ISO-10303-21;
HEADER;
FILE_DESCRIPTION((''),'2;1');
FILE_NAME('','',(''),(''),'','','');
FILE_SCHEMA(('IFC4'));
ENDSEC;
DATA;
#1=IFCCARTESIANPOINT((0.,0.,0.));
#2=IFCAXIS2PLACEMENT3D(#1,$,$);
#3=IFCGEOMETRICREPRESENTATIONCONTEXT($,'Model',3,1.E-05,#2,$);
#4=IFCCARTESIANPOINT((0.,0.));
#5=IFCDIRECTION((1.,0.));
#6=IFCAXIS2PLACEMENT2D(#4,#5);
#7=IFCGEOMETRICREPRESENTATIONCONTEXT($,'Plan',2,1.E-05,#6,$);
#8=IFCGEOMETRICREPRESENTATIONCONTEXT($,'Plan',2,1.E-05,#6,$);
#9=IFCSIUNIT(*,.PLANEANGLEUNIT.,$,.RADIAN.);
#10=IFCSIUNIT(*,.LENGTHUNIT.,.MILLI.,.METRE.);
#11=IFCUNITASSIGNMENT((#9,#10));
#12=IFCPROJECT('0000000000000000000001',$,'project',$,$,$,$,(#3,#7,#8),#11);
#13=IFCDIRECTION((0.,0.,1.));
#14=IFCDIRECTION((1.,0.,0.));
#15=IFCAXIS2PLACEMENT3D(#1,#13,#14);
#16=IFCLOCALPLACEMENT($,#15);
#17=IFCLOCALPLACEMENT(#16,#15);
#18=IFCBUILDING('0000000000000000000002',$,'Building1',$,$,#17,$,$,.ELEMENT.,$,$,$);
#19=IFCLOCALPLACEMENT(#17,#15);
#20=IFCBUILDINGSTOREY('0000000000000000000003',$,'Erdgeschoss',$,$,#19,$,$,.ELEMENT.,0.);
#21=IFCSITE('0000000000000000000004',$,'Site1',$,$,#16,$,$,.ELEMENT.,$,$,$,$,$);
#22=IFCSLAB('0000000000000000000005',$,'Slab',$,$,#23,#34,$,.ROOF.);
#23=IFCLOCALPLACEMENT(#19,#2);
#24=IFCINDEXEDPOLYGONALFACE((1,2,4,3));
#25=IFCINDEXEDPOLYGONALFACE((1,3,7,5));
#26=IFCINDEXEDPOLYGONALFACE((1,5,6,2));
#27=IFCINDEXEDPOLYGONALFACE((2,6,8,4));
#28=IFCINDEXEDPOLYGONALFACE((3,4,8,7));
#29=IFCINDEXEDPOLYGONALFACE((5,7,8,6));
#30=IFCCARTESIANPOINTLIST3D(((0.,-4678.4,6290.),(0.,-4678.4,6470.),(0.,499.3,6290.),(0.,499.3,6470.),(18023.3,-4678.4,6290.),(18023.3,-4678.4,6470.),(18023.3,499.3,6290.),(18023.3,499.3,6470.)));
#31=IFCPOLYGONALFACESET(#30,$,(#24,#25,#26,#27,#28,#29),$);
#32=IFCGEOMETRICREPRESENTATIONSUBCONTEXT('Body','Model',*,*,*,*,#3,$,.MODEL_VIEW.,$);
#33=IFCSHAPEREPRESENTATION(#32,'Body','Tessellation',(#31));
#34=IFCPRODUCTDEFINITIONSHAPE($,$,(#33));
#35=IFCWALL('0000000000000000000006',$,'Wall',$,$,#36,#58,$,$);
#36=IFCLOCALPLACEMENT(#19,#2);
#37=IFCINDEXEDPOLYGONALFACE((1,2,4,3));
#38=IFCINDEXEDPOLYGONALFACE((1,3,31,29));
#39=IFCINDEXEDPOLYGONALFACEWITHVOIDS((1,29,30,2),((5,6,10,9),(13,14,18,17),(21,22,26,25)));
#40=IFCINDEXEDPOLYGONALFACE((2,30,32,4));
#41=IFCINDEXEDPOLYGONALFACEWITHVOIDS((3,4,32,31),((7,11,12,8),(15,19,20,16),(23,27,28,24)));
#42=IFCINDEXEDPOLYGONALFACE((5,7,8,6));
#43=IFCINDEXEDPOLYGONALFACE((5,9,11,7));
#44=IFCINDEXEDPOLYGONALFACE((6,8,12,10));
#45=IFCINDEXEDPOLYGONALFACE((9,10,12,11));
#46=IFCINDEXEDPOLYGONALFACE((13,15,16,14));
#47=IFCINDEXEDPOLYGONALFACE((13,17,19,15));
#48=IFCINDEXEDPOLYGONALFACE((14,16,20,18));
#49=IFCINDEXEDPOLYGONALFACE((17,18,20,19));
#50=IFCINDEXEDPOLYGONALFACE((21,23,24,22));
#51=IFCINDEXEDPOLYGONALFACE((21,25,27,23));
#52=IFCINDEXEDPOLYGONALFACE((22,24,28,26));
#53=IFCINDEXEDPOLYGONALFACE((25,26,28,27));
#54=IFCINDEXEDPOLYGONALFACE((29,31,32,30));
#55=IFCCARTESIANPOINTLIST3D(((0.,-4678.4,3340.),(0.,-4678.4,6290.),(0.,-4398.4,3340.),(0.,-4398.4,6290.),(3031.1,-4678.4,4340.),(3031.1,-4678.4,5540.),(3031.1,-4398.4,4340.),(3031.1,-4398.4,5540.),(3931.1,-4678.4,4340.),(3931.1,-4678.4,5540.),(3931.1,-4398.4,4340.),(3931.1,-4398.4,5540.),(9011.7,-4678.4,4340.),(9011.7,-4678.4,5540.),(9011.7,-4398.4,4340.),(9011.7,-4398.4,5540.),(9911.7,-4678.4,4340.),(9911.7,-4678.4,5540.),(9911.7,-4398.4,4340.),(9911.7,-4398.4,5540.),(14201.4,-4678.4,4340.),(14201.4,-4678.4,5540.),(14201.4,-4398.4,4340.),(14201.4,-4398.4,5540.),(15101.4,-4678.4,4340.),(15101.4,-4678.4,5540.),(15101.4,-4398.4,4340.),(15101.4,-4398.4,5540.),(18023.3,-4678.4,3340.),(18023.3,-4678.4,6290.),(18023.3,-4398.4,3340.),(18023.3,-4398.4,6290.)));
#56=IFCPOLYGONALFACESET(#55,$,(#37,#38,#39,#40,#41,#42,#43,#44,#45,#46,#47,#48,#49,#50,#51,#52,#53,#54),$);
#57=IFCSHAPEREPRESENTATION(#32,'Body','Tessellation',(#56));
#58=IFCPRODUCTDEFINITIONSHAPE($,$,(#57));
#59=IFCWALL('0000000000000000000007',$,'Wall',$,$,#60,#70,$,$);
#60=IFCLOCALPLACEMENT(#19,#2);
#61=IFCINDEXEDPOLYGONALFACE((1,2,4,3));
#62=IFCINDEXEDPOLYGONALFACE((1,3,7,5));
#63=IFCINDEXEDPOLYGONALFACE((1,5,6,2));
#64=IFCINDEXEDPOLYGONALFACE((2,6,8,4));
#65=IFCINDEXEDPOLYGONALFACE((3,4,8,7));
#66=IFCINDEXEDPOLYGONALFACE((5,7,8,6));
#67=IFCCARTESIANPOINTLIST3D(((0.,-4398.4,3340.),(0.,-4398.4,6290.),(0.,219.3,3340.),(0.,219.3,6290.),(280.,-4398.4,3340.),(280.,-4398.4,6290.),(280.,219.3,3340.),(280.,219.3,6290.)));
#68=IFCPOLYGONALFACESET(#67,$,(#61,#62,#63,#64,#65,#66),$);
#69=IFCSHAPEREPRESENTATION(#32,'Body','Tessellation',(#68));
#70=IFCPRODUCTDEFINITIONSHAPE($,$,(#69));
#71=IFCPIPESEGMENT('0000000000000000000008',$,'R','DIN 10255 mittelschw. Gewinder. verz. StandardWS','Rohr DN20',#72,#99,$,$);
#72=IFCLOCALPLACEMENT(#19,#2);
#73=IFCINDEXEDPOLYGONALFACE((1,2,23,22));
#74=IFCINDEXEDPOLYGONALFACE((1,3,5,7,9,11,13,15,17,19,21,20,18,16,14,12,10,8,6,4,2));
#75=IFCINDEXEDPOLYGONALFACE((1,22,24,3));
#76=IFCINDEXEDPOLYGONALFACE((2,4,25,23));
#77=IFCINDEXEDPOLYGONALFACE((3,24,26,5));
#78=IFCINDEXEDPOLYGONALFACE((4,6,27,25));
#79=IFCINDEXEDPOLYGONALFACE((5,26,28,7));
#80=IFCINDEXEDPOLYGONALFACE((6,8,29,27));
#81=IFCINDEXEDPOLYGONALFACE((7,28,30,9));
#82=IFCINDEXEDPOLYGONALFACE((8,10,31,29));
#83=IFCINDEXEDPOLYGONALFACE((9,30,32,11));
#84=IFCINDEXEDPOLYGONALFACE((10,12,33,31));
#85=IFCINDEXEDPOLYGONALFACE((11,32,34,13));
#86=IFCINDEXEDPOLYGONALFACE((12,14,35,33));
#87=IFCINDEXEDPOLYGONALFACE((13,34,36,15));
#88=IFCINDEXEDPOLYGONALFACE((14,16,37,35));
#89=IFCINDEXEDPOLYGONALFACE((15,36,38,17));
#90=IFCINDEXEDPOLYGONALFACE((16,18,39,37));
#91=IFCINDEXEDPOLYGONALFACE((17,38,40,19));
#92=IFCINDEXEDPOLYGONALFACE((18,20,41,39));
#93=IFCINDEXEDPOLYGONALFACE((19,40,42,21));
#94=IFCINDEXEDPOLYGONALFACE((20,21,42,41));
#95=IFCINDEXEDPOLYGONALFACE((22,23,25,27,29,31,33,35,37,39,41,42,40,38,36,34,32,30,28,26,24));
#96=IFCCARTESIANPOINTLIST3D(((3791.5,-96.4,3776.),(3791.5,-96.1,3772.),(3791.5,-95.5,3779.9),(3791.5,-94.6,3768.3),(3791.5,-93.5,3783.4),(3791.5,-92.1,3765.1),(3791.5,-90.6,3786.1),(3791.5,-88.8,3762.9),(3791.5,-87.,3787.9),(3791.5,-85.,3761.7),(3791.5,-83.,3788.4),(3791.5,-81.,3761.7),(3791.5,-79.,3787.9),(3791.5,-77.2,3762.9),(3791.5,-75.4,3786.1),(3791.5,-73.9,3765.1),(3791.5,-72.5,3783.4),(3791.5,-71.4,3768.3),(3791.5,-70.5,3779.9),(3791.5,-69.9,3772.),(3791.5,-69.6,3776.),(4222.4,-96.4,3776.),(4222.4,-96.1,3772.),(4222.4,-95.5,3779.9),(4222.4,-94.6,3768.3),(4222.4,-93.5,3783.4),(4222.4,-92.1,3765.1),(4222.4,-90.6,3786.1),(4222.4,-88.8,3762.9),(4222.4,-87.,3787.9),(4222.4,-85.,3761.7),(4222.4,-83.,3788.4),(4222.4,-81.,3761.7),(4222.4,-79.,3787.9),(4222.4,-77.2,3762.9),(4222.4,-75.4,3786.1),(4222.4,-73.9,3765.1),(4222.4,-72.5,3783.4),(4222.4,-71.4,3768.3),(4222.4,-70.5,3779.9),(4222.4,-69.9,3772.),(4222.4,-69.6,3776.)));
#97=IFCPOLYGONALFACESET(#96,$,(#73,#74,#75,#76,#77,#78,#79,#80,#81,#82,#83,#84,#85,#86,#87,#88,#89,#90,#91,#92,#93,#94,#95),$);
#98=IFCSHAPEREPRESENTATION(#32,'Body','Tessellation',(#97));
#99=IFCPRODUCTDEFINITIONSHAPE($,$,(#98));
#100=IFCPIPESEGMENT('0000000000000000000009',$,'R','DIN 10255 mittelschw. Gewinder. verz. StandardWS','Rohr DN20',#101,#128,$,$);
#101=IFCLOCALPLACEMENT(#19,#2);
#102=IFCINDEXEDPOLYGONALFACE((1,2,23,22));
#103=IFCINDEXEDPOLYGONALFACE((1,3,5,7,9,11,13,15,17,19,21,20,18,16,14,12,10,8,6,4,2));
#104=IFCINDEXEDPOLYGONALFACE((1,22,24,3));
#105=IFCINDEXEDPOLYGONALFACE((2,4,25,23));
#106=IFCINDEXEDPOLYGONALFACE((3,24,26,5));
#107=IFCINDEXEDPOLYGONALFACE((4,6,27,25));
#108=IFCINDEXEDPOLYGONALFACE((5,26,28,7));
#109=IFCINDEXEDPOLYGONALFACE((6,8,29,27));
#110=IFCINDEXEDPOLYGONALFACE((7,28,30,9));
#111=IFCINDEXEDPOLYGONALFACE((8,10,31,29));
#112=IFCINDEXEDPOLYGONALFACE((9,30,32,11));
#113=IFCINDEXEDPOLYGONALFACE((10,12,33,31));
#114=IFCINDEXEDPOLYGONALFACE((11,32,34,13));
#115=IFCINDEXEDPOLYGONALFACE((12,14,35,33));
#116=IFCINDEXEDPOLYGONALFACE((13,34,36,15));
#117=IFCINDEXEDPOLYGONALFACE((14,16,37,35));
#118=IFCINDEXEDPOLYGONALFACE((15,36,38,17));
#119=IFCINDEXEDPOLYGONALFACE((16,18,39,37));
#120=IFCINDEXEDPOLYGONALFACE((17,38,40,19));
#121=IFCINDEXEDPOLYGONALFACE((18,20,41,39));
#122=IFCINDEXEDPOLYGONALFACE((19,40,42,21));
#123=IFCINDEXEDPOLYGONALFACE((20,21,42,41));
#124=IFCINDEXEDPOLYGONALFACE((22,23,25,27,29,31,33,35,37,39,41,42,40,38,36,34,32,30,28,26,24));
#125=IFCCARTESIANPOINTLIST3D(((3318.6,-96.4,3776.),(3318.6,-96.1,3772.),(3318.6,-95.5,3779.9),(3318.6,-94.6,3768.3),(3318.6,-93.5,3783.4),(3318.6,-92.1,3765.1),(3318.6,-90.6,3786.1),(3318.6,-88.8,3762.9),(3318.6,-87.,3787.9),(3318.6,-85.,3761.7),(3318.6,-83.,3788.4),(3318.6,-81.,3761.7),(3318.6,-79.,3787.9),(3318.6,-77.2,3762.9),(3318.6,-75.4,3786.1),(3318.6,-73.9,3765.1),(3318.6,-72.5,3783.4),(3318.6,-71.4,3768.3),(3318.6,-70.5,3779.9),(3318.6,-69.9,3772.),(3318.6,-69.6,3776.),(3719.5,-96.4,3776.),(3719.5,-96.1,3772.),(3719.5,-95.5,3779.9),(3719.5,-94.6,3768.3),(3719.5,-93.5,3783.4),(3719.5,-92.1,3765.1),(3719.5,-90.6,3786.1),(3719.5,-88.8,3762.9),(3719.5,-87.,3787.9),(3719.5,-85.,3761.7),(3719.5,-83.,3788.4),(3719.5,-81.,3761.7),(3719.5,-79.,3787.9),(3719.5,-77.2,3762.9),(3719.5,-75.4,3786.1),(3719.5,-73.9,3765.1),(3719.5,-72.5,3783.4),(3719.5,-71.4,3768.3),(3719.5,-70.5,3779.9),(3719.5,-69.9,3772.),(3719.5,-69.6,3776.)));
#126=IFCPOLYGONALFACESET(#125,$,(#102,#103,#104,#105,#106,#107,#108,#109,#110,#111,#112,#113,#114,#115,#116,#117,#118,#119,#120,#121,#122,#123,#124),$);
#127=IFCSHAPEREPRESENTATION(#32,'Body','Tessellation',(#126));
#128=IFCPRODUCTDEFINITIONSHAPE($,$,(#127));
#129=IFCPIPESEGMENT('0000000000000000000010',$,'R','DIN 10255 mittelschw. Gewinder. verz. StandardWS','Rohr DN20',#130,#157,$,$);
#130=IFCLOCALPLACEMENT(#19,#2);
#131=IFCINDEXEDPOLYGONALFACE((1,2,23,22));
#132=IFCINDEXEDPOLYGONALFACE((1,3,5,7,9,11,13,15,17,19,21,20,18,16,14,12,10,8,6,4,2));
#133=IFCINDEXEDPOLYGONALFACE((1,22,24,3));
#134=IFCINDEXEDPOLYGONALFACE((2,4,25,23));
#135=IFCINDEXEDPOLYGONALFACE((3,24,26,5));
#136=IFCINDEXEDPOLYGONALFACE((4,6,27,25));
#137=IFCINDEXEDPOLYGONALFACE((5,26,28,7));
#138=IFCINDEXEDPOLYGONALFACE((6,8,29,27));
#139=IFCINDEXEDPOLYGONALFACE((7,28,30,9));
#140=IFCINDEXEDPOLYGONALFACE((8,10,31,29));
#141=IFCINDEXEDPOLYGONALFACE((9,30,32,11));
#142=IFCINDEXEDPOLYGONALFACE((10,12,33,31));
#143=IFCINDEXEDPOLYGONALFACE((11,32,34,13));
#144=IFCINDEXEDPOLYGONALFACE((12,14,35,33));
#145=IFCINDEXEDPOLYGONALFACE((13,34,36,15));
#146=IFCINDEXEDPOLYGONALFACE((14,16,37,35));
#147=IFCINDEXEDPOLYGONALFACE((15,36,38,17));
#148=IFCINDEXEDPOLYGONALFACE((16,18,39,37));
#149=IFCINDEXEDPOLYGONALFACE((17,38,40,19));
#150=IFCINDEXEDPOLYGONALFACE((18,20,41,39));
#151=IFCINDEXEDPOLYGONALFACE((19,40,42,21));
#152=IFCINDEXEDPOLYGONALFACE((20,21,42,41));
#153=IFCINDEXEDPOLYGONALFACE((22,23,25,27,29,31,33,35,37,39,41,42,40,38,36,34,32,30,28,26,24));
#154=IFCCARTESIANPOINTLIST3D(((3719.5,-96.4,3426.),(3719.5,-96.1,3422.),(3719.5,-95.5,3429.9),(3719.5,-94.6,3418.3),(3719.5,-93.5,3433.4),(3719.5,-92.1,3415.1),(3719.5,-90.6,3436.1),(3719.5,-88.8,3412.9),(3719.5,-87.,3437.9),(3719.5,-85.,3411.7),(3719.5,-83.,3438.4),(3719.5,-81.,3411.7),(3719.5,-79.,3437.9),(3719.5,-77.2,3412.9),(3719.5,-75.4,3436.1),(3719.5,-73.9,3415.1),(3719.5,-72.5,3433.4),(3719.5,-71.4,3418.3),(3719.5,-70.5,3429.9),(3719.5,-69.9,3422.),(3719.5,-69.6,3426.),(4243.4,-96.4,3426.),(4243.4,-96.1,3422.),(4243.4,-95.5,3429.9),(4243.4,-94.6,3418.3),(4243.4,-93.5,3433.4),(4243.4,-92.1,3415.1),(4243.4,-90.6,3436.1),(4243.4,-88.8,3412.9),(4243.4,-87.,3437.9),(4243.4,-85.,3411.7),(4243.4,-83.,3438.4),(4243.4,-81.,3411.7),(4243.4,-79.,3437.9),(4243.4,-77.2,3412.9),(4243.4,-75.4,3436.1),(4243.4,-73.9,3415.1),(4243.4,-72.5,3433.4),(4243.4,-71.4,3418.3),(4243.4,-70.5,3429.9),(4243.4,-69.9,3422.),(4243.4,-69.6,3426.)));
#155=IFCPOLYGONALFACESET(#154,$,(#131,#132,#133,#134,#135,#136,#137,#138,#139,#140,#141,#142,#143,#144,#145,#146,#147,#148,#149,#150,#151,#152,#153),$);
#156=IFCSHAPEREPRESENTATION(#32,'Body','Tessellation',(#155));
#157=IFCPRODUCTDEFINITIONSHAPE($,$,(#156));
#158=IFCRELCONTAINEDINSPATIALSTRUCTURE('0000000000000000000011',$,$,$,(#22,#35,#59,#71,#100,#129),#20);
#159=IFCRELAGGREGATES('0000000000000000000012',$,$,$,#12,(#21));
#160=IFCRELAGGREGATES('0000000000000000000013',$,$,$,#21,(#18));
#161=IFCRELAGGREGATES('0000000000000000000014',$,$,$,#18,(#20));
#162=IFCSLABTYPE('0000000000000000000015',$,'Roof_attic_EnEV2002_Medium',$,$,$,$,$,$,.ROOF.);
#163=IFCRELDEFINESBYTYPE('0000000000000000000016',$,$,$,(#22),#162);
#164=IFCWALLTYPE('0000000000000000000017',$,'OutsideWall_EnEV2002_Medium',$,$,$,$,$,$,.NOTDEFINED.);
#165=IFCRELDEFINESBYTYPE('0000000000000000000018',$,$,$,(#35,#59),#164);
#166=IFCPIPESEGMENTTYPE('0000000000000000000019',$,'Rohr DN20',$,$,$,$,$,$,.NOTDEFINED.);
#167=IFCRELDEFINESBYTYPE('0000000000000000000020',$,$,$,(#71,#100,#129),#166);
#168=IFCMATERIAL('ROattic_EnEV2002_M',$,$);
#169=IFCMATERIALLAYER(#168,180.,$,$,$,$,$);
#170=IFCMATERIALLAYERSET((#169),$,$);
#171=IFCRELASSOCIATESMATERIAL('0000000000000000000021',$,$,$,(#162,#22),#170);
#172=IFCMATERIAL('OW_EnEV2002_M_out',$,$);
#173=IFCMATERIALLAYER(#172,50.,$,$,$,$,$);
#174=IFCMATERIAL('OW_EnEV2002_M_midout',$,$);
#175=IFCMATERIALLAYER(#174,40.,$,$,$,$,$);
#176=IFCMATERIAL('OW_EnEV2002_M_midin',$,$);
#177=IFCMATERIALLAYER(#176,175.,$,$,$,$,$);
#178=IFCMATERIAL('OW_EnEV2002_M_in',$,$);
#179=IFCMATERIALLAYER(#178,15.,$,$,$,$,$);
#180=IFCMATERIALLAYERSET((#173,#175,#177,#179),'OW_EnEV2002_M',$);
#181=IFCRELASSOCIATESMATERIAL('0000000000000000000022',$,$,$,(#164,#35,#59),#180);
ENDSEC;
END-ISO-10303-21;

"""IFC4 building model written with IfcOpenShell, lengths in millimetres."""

from ifc_helpers import new_model, si_unit, frame, origin, origin_with_axes, origin_2d_with_axis, place, context, subcontext, project, spatial, line, indexed_curve, circle, outline, extrude, source, transform, mapped, material, layer, layer_set, layer_usage, type_object, element, save


model = new_model("IFC4")

# Units and contexts
model_context = context("Model", 3, precision=1e-05, world=origin())
plan_context_1 = context("Plan", 2, precision=1e-05, world=origin_2d_with_axis())
plan_context_2 = context("Plan", 2, precision=1e-05, world=origin_2d_with_axis())
body_context = subcontext(model_context, "Body", "Model", "MODEL_VIEW")
ifc_project = project(units=[si_unit("PLANEANGLEUNIT", "RADIAN"), si_unit("LENGTHUNIT", "METRE", prefix="MILLI")], contexts=[model_context, plan_context_1, plan_context_2])

# Site, building, storey
site_placement = place(None, origin_with_axes())
site = spatial("IfcSite", under=ifc_project, at=site_placement, Name="Site1", CompositionType="ELEMENT")
building_placement = place(site_placement, origin_with_axes())
building = spatial("IfcBuilding", under=site, at=building_placement, Name="Building1", CompositionType="ELEMENT")
storey_placement = place(building_placement, origin_with_axes())
storey = spatial("IfcBuildingStorey", under=building, at=storey_placement, Name="Erdgeschoss", CompositionType="ELEMENT", Elevation=0.0)

# Slab
ifc_material_1 = material(Name="ROattic_EnEV2002_M")
ifc_layer_1 = layer(ifc_material_1, 180.0)
ifc_layer_set_1 = layer_set([ifc_layer_1])
ifc_layer_usage_1 = layer_usage(ifc_layer_set_1, "AXIS3", "POSITIVE", 0.0)
slab_type = type_object("IfcSlabType", Name="Roof_attic_EnEV2002_Medium", PredefinedType="ROOF", material=ifc_layer_set_1)
slab_placement = place(storey_placement, frame((0.0, -4678.4, 6290.0), z_axis=(0.0, 0.0, 1.0), x_axis=(1.0, 0.0, 0.0)))
element("IfcSlab", 1, at=slab_placement, inside=storey, type_object=slab_type, material=ifc_layer_usage_1, Name="Slab", PredefinedType="ROOF", context=body_context, shape_type="SweptSolid", body=[
    extrude(outline(indexed_curve([(0.0, 0.0), (18023.3, 0.0), (18023.3, 5177.6), (0.0, 5177.6)], segments=[line(4, 1), line(1, 2), line(2, 3), line(3, 4)], self_intersect=False)), None, (0.0, 0.0, 1.0), 180.0),
])

# Wall, openings
ifc_material_2 = material(Name="OW_EnEV2002_M_out")
ifc_layer_2 = layer(ifc_material_2, 50.0)
ifc_material_3 = material(Name="OW_EnEV2002_M_midout")
ifc_layer_3 = layer(ifc_material_3, 40.0)
ifc_material_4 = material(Name="OW_EnEV2002_M_midin")
ifc_layer_4 = layer(ifc_material_4, 175.0)
ifc_material_5 = material(Name="OW_EnEV2002_M_in")
ifc_layer_5 = layer(ifc_material_5, 15.0)
ifc_layer_set_2 = layer_set([ifc_layer_2, ifc_layer_3, ifc_layer_4, ifc_layer_5], Name="OW_EnEV2002_M")
ifc_layer_usage_2 = layer_usage(ifc_layer_set_2, "AXIS2", "POSITIVE", 0.0)
wall_type = type_object("IfcWallType", Name="OutsideWall_EnEV2002_Medium", PredefinedType="NOTDEFINED", material=ifc_layer_set_2)
wall_1_placement = place(storey_placement, frame((0.0, -4678.4, 3340.0), z_axis=(0.0, 0.0, 1.0), x_axis=(1.0, 0.0, 0.0)))
wall_1 = element("IfcWall", 2, at=wall_1_placement, inside=storey, type_object=wall_type, material=ifc_layer_usage_2, Name="Wall", context=body_context, shape_type="SweptSolid", body=[
    extrude(outline(indexed_curve([(0.0, 0.0), (0.0, 280.0), (18023.3, 280.0), (18023.3, 0.0), (0.0, 0.0)], self_intersect=False)), origin_with_axes(), (0.0, 0.0, 1.0), 2950.0),
])
shared_shape_1 = source(origin_with_axes(), body_context, "Body", "SweptSolid", [
    extrude(outline(indexed_curve([(0.0, 0.0), (900.0, 0.0), (900.0, 1200.0), (0.0, 1200.0)], segments=[line(1, 2, 3, 4, 1)])), frame((0.0, -600.0, 0.0), z_axis=(0.0, -1.0, 0.0), x_axis=(1.0, 0.0, 0.0)), (0.0, 0.0, -1.0), 1200.0),
])
opening_1_placement = place(wall_1_placement, frame((3031.1, 0.0, 1000.0), z_axis=(0.0, 0.0, 1.0), x_axis=(1.0, 0.0, 0.0)))
element("IfcOpeningElement", 3, at=opening_1_placement, cuts=wall_1, PredefinedType="OPENING", context=body_context, shape_type="MappedRepresentation", body=[
    mapped(shared_shape_1, transform((0.0, 0.0, 0.0), x_axis=(1.0, 0.0, 0.0), y_axis=(0.0, 1.0, 0.0), z_axis=(0.0, 0.0, 1.0), scale=1.0)),
])
opening_2_placement = place(wall_1_placement, frame((9011.7, 0.0, 1000.0), z_axis=(0.0, 0.0, 1.0), x_axis=(1.0, 0.0, 0.0)))
element("IfcOpeningElement", 4, at=opening_2_placement, cuts=wall_1, PredefinedType="OPENING", context=body_context, shape_type="MappedRepresentation", body=[
    mapped(shared_shape_1, transform((0.0, 0.0, 0.0), x_axis=(1.0, 0.0, 0.0), y_axis=(0.0, 1.0, 0.0), z_axis=(0.0, 0.0, 1.0), scale=1.0)),
])
opening_3_placement = place(wall_1_placement, frame((14201.4, 0.0, 1000.0), z_axis=(0.0, 0.0, 1.0), x_axis=(1.0, 0.0, 0.0)))
element("IfcOpeningElement", 5, at=opening_3_placement, cuts=wall_1, PredefinedType="OPENING", context=body_context, shape_type="MappedRepresentation", body=[
    mapped(shared_shape_1, transform((0.0, 0.0, 0.0), x_axis=(1.0, 0.0, 0.0), y_axis=(0.0, 1.0, 0.0), z_axis=(0.0, 0.0, 1.0), scale=1.0)),
])

# Wall
ifc_layer_usage_3 = layer_usage(ifc_layer_set_2, "AXIS2", "POSITIVE", 0.0)
wall_2_placement = place(storey_placement, frame((0.0, 219.3, 3340.0), z_axis=(0.0, 0.0, 1.0), x_axis=(-0.000001, -1.0, 0.0)))
element("IfcWall", 6, at=wall_2_placement, inside=storey, type_object=wall_type, material=ifc_layer_usage_3, Name="Wall", context=body_context, shape_type="SweptSolid", body=[
    extrude(outline(indexed_curve([(0.0, 0.0), (0.0, 280.0), (4617.6, 280.0), (4617.6, 0.0), (0.0, 0.0)], self_intersect=False)), origin_with_axes(), (0.0, 0.0, 1.0), 2950.0),
])

# Pipe segments
pipe_segment_type_1 = type_object("IfcPipeSegmentType", Name="Rohr DN20", PredefinedType="NOTDEFINED")
pipe_segment_1_placement = place(storey_placement, frame((4006.9, -83.2, 3775.0), z_axis=(0.0, 0.0, 1.0), x_axis=(1.0, 0.0, 0.0)))
element("IfcPipeSegment", 7, at=pipe_segment_1_placement, inside=storey, type_object=pipe_segment_type_1, Name="R", Description="DIN 10255 mittelschw. Gewinder. verz. StandardWS", ObjectType="Rohr DN20", context=body_context, shape_type="SolidModel", body=[
    extrude(circle(Radius=13.4, at=origin_2d_with_axis()), frame((215.5, 0.2, 0.0), z_axis=(-1.0, 0.0, 0.0), x_axis=(0.0, 0.0, 1.0)), (0.0, 0.0, 1.0), 430.9),
])
pipe_segment_2_placement = place(storey_placement, frame((3519.0, -83.2, 3775.0), z_axis=(0.0, 0.0, 1.0), x_axis=(1.0, 0.0, 0.0)))
element("IfcPipeSegment", 8, at=pipe_segment_2_placement, inside=storey, type_object=pipe_segment_type_1, Name="R", Description="DIN 10255 mittelschw. Gewinder. verz. StandardWS", ObjectType="Rohr DN20", context=body_context, shape_type="SolidModel", body=[
    extrude(circle(Radius=13.4, at=origin_2d_with_axis()), frame((200.5, 0.2, 0.0), z_axis=(-1.0, 0.0, 0.0), x_axis=(0.0, 0.0, 1.0)), (0.0, 0.0, 1.0), 400.9),
])
pipe_segment_3_placement = place(storey_placement, frame((3981.4, -83.2, 3425.0), z_axis=(0.0, 0.0, 1.0), x_axis=(1.0, 0.0, 0.0)))
element("IfcPipeSegment", 9, at=pipe_segment_3_placement, inside=storey, type_object=pipe_segment_type_1, Name="R", Description="DIN 10255 mittelschw. Gewinder. verz. StandardWS", ObjectType="Rohr DN20", context=body_context, shape_type="SolidModel", body=[
    extrude(circle(Radius=13.4, at=origin_2d_with_axis()), frame((261.9, 0.2, 0.0), z_axis=(-1.0, 0.0, 0.0), x_axis=(0.0, 0.0, 1.0)), (0.0, 0.0, 1.0), 523.9),
])

save(model, "model.ifc")
